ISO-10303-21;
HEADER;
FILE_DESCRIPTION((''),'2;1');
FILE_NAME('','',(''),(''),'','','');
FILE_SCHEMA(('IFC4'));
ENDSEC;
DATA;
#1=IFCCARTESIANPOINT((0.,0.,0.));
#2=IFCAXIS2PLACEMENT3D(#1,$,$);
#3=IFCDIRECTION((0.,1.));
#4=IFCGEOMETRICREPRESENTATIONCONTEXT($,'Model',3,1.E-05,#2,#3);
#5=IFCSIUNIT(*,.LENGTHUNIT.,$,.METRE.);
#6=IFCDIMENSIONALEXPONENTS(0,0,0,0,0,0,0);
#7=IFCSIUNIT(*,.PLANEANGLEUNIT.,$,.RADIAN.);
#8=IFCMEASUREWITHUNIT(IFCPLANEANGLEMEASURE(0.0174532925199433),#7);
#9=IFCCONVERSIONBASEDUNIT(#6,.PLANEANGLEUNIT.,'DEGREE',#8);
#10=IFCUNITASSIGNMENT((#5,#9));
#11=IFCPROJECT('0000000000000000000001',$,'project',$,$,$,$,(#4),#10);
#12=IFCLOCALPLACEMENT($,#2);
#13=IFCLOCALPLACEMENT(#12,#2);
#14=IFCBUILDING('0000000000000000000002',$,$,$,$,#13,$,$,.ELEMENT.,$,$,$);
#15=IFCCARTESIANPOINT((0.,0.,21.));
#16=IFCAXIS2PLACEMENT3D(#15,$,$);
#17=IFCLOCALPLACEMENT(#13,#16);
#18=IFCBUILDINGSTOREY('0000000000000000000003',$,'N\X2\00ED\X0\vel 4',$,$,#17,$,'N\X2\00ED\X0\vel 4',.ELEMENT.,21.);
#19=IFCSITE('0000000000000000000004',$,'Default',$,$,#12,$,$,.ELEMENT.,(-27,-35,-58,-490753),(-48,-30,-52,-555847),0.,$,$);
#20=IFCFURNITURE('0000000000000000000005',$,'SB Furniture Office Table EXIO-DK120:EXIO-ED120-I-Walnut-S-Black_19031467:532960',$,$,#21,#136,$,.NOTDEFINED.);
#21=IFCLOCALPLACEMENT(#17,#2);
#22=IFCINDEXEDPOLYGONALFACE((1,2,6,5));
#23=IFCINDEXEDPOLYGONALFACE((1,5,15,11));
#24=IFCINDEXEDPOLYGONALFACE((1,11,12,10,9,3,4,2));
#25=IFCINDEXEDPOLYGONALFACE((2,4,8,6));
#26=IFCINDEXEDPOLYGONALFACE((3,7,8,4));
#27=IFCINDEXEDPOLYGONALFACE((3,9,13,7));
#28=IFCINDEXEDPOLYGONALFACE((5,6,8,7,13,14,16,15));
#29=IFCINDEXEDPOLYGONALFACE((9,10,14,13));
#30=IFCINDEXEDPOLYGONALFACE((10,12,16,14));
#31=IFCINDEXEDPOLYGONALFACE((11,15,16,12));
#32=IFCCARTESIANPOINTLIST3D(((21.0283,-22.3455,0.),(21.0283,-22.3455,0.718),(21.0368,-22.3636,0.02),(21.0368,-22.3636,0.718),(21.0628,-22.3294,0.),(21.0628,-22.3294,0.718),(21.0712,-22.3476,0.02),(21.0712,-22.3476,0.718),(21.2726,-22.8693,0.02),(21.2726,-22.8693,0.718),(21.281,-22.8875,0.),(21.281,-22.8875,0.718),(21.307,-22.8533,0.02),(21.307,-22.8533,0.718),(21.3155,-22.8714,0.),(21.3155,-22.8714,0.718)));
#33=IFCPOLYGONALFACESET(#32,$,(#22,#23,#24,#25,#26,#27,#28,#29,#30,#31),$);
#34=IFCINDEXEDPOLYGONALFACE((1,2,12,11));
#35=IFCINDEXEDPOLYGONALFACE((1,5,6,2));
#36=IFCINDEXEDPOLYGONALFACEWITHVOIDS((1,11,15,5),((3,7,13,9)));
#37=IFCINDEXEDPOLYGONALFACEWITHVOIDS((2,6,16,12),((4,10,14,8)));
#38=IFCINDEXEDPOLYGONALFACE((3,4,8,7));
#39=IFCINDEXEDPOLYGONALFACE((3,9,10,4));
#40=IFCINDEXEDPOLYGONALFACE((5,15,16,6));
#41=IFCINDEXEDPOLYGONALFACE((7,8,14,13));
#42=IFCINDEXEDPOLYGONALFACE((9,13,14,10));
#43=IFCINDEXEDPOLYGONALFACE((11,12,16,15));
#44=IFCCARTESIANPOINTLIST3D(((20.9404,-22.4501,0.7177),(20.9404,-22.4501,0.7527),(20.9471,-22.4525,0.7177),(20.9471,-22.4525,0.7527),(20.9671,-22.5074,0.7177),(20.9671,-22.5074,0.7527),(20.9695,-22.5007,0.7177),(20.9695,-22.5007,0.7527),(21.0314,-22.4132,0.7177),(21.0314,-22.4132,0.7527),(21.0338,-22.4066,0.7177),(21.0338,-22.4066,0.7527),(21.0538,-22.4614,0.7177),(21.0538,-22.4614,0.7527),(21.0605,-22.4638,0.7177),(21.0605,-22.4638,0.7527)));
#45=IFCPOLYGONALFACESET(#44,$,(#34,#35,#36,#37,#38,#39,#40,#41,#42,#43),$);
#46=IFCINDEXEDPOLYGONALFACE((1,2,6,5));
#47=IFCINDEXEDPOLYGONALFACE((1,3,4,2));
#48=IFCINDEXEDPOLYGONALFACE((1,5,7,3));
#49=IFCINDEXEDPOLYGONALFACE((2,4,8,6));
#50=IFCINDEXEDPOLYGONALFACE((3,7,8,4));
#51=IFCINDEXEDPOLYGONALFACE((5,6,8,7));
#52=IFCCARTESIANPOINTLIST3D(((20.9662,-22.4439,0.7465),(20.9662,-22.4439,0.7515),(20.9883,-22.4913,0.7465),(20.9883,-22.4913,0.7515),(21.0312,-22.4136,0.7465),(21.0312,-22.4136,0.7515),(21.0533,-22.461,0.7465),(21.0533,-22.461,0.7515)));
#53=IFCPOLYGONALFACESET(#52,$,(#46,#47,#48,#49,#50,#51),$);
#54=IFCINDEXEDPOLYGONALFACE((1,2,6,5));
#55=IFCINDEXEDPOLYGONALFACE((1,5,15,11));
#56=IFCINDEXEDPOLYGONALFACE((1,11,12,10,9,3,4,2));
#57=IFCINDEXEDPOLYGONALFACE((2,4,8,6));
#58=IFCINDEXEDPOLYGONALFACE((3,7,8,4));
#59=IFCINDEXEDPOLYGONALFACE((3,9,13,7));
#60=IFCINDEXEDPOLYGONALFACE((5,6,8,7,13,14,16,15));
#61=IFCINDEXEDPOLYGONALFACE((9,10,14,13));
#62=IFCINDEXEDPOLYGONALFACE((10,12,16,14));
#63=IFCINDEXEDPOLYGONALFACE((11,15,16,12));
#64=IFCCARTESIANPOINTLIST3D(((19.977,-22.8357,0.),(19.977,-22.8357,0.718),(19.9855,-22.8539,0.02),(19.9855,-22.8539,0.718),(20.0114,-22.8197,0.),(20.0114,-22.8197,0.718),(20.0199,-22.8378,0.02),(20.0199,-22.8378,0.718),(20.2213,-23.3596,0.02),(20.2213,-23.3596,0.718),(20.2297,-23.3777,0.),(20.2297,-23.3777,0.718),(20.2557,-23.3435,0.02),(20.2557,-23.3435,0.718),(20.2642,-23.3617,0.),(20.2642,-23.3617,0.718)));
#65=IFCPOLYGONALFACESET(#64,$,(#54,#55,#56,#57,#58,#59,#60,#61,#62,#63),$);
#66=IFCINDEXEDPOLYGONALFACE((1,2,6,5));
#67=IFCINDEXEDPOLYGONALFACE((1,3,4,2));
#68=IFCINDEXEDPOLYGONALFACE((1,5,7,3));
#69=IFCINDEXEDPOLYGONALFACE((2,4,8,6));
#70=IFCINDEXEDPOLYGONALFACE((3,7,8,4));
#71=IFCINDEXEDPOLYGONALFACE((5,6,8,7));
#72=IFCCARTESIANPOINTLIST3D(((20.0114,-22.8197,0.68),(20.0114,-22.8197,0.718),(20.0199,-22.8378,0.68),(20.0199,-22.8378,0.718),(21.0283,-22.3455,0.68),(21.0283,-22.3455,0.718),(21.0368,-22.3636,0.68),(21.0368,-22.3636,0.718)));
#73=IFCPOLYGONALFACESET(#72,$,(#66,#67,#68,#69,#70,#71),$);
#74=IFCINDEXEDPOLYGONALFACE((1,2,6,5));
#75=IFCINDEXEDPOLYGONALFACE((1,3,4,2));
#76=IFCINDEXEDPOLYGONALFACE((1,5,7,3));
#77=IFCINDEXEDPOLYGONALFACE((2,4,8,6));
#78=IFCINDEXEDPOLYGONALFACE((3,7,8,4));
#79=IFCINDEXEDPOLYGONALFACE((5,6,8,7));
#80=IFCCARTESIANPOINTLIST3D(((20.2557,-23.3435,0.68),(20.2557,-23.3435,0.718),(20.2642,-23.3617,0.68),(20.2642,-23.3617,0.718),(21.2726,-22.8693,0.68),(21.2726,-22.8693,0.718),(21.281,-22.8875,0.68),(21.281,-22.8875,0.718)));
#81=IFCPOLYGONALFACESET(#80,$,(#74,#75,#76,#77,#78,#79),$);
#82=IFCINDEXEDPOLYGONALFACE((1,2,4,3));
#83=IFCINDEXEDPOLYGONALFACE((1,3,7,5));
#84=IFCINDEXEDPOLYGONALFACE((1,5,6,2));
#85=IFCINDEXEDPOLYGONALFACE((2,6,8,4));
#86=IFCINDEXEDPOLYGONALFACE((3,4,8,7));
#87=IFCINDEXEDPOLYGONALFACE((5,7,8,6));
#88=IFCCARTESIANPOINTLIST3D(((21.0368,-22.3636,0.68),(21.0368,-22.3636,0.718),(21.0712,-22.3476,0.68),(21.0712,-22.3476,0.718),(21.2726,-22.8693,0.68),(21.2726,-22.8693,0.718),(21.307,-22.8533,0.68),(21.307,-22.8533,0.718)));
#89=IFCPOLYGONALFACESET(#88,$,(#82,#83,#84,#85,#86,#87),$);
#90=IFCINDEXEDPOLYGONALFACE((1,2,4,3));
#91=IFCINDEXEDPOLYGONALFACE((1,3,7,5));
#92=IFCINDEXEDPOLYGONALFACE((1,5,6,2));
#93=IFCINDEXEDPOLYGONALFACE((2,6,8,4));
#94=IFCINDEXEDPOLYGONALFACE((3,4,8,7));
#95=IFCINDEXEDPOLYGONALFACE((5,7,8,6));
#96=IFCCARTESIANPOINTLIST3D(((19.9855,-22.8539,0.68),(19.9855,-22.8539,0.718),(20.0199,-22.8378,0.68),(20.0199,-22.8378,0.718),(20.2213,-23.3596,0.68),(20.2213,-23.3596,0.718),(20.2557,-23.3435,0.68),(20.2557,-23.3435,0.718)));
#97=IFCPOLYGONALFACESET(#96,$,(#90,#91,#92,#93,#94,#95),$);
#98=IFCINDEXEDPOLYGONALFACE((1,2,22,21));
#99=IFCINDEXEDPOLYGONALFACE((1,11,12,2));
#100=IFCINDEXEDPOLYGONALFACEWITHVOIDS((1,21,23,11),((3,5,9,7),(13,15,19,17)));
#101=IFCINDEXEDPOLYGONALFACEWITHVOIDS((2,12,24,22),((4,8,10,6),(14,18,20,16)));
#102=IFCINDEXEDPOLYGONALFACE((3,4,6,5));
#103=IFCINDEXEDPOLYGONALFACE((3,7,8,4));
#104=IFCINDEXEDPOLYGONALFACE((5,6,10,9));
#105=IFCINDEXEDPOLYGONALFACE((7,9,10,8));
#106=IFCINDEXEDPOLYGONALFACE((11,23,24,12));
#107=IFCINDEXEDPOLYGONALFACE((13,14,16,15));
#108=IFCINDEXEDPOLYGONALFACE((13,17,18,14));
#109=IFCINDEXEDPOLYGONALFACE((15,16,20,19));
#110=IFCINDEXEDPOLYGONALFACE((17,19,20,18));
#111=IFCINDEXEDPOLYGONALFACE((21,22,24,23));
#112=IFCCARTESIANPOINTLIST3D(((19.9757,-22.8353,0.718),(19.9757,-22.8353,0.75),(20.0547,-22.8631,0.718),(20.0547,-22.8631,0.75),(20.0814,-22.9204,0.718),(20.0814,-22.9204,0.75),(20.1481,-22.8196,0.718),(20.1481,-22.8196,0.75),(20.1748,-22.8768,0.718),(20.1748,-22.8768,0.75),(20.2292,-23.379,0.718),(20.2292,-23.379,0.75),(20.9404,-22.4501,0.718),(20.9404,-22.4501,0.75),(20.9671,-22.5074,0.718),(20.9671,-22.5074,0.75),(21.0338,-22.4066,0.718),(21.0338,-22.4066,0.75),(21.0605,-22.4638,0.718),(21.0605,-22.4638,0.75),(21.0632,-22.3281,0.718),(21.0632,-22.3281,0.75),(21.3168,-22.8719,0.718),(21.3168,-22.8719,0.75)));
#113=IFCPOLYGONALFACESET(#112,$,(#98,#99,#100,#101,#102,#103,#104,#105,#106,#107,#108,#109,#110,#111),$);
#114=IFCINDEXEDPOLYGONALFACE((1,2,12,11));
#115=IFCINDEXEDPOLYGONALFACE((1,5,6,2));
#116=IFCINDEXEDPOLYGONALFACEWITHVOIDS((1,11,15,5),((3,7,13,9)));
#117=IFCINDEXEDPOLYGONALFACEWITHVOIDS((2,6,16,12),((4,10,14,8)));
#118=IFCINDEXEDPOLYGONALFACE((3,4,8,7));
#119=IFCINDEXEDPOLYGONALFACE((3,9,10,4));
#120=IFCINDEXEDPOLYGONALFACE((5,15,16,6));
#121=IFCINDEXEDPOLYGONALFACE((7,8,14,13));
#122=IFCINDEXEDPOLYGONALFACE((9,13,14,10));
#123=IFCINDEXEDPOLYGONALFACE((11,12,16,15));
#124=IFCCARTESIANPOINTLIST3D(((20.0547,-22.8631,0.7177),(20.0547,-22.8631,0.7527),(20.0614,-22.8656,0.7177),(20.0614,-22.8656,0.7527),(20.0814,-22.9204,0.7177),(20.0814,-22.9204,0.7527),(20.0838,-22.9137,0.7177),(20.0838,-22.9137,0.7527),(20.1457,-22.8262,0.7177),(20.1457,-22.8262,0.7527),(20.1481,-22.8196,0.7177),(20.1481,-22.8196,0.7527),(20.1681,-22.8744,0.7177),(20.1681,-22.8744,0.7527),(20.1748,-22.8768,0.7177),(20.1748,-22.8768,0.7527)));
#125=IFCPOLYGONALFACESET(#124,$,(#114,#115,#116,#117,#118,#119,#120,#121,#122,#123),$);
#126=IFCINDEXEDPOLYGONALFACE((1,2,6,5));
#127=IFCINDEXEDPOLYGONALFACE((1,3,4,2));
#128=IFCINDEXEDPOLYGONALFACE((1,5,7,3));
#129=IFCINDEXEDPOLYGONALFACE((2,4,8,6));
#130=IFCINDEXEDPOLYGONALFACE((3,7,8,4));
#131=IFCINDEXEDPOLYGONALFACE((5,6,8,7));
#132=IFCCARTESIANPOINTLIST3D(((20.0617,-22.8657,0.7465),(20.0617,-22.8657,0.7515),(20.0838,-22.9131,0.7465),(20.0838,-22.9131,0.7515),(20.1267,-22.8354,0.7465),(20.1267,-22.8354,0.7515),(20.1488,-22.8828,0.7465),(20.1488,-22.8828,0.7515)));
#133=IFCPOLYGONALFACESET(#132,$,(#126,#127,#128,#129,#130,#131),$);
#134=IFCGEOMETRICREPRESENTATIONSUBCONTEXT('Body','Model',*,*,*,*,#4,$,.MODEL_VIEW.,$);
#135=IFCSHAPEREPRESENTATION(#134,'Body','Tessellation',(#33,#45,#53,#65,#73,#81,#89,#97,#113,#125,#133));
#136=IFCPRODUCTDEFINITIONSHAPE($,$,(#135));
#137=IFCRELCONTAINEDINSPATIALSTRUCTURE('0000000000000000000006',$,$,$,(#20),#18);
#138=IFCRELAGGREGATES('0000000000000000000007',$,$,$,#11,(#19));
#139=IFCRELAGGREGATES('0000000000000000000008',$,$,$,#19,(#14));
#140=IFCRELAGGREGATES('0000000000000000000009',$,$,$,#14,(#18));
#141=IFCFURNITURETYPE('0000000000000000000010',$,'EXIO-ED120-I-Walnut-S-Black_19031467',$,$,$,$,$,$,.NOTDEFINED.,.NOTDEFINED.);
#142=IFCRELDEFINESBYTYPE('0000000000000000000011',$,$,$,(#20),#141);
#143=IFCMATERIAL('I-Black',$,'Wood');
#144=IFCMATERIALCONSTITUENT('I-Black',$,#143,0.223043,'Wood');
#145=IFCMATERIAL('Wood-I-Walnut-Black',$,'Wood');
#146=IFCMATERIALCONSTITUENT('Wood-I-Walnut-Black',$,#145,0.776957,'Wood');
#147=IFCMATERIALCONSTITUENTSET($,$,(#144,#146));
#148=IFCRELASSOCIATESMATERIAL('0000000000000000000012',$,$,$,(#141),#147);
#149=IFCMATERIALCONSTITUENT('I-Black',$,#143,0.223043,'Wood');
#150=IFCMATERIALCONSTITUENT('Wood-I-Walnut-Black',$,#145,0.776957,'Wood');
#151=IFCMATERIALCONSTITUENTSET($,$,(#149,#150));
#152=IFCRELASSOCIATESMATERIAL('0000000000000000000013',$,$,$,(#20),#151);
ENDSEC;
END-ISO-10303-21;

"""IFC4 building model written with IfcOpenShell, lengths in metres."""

from ifc_helpers import new_model, entity, si_unit, converted_unit, direction, frame, frame_2d, origin, origin_2d_with_axis, place, context, subcontext, project, spatial, polyline, rectangle, outline, extrude, source, transform, mapped, material, constituent, constituent_set, type_object, type_shapes, element, save


model = new_model("IFC4")

# Units and contexts
model_context = context("Model", 3, precision=1e-05, world=origin(), true_north=direction((0.0, 1.0)))
body_context = subcontext(model_context, "Body", "Model", "MODEL_VIEW")
ifc_project = project(units=[si_unit("LENGTHUNIT", "METRE"), converted_unit("PLANEANGLEUNIT", "DEGREE", entity("IfcPlaneAngleMeasure", 0.0174532925199433), si_unit("PLANEANGLEUNIT", "RADIAN"), dimensions=[0, 0, 0, 0, 0, 0, 0])], contexts=[model_context])

# Site, building, storey
site_placement = place(None, origin())
site = spatial("IfcSite", under=ifc_project, at=site_placement, Name="Default", CompositionType="ELEMENT", RefLatitude=(-27, -35, -58, -490753), RefLongitude=(-48, -30, -52, -555847), RefElevation=0.0)
building_placement = place(site_placement, origin())
building = spatial("IfcBuilding", under=site, at=building_placement, CompositionType="ELEMENT")
storey_placement = place(building_placement, frame((0.0, 0.0, 21.0)))
storey = spatial("IfcBuildingStorey", under=building, at=storey_placement, Name="Nível 4", LongName="Nível 4", CompositionType="ELEMENT", Elevation=21.0)

# Furniture
ifc_material_1 = material(Name="I-Black", Category="Wood")
ifc_material_2 = material(Name="Wood-I-Walnut-Black", Category="Wood")
ifc_constituent_1 = constituent(ifc_material_1, Name="I-Black", Category="Wood", fraction=0.223043)
ifc_constituent_2 = constituent(ifc_material_2, Name="Wood-I-Walnut-Black", Category="Wood", fraction=0.776957)
ifc_constituent_set_1 = constituent_set(constituents=[ifc_constituent_1, ifc_constituent_2])
furniture_type = type_object("IfcFurnitureType", Name="EXIO-ED120-I-Walnut-S-Black_19031467", AssemblyPlace="NOTDEFINED", PredefinedType="NOTDEFINED", material=ifc_constituent_set_1)
shared_shape_1 = source(origin(), body_context, "Body", "SweptSolid", [
    extrude(outline(polyline([(-0.354, -0.279), (-0.354, -0.299), (0.364, -0.299), (0.364, 0.299), (-0.354, 0.299), (-0.354, 0.279), (0.344, 0.279), (0.344, -0.279), (-0.354, -0.279)])), frame((0.561, 0.0, 0.364), z_axis=(-1.0, 0.0, 0.0), x_axis=(0.0, 0.0, -1.0)), (0.0, 0.0, -1.0), 0.038),
    extrude(outline(polyline([(-0.0316, -0.0515), (0.0316, -0.0515), (0.0316, 0.0515), (-0.0316, 0.0515), (-0.0316, -0.0515)]), holes=[polyline([(0.0266, -0.0465), (-0.0266, -0.0465), (-0.0266, 0.0465), (0.0266, 0.0465), (0.0266, -0.0465)])]), frame((0.4886, 0.2097, 0.7177), z_axis=(0.0, 0.0, 1.0), x_axis=(0.0, -1.0, 0.0)), (0.0, 0.0, 1.0), 0.035),
    extrude(rectangle(XDim=0.0717, YDim=0.0523, at=origin_2d_with_axis()), frame((0.499, 0.2099, 0.7465), z_axis=(0.0, 0.0, 1.0), x_axis=(-1.0, 0.0, 0.0)), (0.0, 0.0, 1.0), 0.005),
    extrude(outline(polyline([(-0.354, -0.279), (-0.354, -0.299), (0.364, -0.299), (0.364, 0.299), (-0.354, 0.299), (-0.354, 0.279), (0.344, 0.279), (0.344, -0.279), (-0.354, -0.279)])), frame((-0.599, 0.0, 0.364), z_axis=(-1.0, 0.0, 0.0), x_axis=(0.0, 0.0, -1.0)), (0.0, 0.0, -1.0), 0.038),
    extrude(rectangle(XDim=1.122, YDim=0.02, at=frame_2d((0.0, 0.0), x_axis=(1.0, 0.0))), frame((0.0, 0.289, 0.68), z_axis=(0.0, 0.0, 1.0), x_axis=(-1.0, 0.0, 0.0)), (0.0, 0.0, 1.0), 0.038),
    extrude(rectangle(XDim=1.122, YDim=0.02, at=origin_2d_with_axis()), frame((0.0, -0.289, 0.68), z_axis=(0.0, 0.0, 1.0), x_axis=(-1.0, 0.0, 0.0)), (0.0, 0.0, 1.0), 0.038),
    extrude(rectangle(XDim=0.038, YDim=0.558, at=frame_2d((0.0, 0.0), x_axis=(1.0, 0.0))), frame((0.58, 0.0, 0.68), z_axis=(0.0, 0.0, 1.0), x_axis=(-1.0, 0.0, 0.0)), (0.0, 0.0, 1.0), 0.038),
    extrude(rectangle(XDim=0.038, YDim=0.558, at=origin_2d_with_axis()), frame((-0.58, 0.0, 0.68), z_axis=(0.0, 0.0, 1.0), x_axis=(-1.0, 0.0, 0.0)), (0.0, 0.0, 1.0), 0.038),
    extrude(outline(polyline([(-0.6, -0.3), (0.6, -0.3), (0.6, 0.3), (-0.6, 0.3), (-0.6, -0.3)]), holes=[polyline([(0.4371, -0.2413), (0.4371, -0.1782), (0.5401, -0.1782), (0.5401, -0.2413), (0.4371, -0.2413)]), polyline([(-0.5401, -0.2413), (-0.5401, -0.1782), (-0.4371, -0.1782), (-0.4371, -0.2413), (-0.5401, -0.2413)])]), frame((0.0, 0.0, 0.718), z_axis=(0.0, 0.0, 1.0), x_axis=(-1.0, 0.0, 0.0)), (0.0, 0.0, 1.0), 0.032),
    extrude(outline(polyline([(-0.0316, -0.0515), (0.0316, -0.0515), (0.0316, 0.0515), (-0.0316, 0.0515), (-0.0316, -0.0515)]), holes=[polyline([(0.0266, -0.0465), (-0.0266, -0.0465), (-0.0266, 0.0465), (0.0266, 0.0465), (0.0266, -0.0465)])]), frame((-0.4886, 0.2097, 0.7177), z_axis=(0.0, 0.0, 1.0), x_axis=(0.0, 1.0, 0.0)), (0.0, 0.0, 1.0), 0.035),
    extrude(rectangle(XDim=0.0523, YDim=0.0717, at=origin_2d_with_axis()), frame((-0.499, 0.2099, 0.7465), z_axis=(0.0, 0.0, 1.0), x_axis=(0.0, -1.0, 0.0)), (0.0, 0.0, 1.0), 0.005),
])
type_shapes(furniture_type, [shared_shape_1])
ifc_constituent_3 = constituent(ifc_material_1, Name="I-Black", Category="Wood", fraction=0.223043)
ifc_constituent_4 = constituent(ifc_material_2, Name="Wood-I-Walnut-Black", Category="Wood", fraction=0.776957)
ifc_constituent_set_2 = constituent_set(constituents=[ifc_constituent_3, ifc_constituent_4])
furniture_1_placement = place(storey_placement, frame((20.6462, -22.8536, 0.0), z_axis=(0.0, 0.0, 1.0), x_axis=(0.906308, 0.422618, 0.0)))
element("IfcFurniture", 1, at=furniture_1_placement, inside=storey, type_object=furniture_type, material=ifc_constituent_set_2, Name="SB Furniture Office Table EXIO-DK120:EXIO-ED120-I-Walnut-S-Black_19031467:532960", PredefinedType="NOTDEFINED", context=body_context, shape_type="MappedRepresentation", body=[
    mapped(shared_shape_1, transform((0.0, 0.0, 0.0), scale=1.0)),
])

save(model, "model.ifc")
